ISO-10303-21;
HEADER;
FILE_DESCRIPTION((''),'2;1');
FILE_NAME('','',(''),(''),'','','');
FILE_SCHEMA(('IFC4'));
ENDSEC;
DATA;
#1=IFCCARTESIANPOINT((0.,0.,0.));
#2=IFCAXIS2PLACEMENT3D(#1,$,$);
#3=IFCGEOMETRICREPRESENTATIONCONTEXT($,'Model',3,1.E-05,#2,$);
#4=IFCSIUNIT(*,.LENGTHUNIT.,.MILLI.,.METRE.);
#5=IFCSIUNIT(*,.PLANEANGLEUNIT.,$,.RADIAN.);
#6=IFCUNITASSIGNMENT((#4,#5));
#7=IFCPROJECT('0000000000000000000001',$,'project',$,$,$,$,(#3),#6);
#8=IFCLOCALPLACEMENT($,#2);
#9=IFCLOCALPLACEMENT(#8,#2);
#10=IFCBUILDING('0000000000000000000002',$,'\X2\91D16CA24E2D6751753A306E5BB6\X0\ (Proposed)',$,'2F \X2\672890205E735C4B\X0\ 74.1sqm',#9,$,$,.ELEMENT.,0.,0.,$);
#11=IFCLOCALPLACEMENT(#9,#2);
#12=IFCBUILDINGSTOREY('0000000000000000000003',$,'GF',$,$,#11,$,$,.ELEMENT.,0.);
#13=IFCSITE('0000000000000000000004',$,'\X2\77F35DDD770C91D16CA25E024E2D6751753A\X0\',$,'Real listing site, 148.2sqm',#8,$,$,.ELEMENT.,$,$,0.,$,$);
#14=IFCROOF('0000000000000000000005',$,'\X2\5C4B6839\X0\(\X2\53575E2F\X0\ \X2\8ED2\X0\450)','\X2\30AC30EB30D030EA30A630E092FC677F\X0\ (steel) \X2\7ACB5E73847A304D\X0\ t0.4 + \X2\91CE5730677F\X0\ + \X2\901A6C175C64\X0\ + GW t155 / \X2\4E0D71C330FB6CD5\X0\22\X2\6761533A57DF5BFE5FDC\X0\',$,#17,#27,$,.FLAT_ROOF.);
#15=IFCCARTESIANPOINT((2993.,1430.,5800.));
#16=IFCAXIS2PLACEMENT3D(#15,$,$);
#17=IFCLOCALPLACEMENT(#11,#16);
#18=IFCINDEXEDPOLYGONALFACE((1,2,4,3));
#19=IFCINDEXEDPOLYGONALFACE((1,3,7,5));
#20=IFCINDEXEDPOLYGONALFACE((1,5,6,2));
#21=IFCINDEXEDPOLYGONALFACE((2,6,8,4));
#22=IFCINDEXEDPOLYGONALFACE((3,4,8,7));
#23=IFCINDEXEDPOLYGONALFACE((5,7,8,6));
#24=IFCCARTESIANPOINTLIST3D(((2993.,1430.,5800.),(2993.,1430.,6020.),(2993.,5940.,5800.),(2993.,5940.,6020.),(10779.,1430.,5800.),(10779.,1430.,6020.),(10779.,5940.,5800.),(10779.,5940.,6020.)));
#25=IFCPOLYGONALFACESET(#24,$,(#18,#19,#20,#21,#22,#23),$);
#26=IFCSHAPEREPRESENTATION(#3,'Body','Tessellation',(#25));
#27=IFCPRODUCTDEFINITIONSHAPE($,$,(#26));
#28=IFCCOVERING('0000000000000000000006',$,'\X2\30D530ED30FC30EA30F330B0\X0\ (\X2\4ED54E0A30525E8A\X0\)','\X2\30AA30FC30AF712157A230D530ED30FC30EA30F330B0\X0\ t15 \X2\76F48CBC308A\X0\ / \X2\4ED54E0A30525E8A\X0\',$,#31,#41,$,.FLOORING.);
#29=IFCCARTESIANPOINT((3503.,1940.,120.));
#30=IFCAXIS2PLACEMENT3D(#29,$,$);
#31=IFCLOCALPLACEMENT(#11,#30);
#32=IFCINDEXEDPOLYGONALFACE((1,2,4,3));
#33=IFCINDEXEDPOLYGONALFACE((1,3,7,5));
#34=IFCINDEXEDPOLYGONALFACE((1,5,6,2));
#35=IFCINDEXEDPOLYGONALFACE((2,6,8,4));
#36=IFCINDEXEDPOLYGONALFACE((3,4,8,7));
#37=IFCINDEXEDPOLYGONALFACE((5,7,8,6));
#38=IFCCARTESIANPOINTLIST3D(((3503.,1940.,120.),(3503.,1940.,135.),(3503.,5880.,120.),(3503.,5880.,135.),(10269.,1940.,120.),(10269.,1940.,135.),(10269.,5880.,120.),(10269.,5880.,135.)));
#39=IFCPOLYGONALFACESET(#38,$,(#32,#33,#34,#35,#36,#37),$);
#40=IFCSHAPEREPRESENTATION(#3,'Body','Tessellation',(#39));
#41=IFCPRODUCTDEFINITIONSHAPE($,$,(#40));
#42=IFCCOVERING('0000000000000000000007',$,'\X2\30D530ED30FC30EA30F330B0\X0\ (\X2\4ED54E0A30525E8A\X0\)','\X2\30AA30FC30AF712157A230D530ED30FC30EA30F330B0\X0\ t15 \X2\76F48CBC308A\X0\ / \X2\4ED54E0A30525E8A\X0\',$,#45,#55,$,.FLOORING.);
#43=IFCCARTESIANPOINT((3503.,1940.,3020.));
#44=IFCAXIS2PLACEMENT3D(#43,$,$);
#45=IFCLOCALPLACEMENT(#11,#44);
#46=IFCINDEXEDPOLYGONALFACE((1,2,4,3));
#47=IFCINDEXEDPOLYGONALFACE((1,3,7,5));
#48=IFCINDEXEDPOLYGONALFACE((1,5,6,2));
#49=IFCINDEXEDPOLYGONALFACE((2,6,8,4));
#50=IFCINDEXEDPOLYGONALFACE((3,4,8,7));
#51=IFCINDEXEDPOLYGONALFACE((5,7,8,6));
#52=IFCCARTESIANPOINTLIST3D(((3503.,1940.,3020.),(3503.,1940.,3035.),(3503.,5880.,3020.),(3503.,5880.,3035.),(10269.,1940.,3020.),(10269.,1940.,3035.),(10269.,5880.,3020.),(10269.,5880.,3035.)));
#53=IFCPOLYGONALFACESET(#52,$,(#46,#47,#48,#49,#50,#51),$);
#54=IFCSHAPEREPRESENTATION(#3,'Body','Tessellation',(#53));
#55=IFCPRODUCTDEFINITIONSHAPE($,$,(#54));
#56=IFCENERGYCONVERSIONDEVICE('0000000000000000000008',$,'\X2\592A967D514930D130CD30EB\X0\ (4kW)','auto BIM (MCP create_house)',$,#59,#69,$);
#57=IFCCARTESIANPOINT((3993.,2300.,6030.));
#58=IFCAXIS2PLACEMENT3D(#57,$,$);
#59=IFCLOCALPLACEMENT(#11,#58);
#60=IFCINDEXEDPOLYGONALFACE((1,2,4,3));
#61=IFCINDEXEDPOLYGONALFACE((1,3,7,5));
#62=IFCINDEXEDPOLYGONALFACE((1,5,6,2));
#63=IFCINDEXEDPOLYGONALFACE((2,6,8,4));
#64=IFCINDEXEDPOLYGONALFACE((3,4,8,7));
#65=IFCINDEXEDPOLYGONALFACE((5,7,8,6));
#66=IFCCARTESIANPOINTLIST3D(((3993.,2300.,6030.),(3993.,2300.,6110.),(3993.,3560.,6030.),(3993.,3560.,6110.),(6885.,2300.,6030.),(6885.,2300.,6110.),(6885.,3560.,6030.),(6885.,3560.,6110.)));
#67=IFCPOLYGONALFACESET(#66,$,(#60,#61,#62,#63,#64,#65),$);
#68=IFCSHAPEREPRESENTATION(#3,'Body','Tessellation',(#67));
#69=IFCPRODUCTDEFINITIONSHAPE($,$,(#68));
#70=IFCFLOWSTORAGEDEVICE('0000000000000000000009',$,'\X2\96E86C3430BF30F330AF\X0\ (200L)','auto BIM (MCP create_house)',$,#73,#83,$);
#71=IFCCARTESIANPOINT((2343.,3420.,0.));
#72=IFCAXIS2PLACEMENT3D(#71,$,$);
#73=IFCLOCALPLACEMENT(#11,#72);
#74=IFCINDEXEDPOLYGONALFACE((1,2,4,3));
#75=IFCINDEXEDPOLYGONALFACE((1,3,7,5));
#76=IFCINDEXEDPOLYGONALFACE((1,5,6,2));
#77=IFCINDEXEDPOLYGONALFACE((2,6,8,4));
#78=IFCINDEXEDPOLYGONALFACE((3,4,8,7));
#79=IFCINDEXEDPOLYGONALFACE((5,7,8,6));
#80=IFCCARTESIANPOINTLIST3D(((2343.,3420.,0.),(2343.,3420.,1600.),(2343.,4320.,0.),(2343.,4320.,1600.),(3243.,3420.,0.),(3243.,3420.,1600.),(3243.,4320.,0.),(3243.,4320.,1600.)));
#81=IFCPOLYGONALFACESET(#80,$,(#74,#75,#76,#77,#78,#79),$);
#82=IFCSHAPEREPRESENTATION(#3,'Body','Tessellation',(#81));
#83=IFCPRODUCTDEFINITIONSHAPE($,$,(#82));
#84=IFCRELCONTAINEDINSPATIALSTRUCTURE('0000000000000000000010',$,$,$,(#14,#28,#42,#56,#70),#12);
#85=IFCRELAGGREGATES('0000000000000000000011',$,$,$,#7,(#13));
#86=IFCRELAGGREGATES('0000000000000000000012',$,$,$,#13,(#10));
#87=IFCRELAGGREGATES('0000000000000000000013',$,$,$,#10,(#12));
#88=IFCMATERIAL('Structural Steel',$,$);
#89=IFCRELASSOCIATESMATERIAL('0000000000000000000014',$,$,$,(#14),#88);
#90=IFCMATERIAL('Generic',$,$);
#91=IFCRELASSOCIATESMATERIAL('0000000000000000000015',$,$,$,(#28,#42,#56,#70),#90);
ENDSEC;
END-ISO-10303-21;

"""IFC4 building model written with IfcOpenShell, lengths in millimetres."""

from ifc_helpers import new_model, si_unit, frame, frame_2d, origin, place, context, project, spatial, rectangle, extrude, material, element, save


model = new_model("IFC4")

# Units and contexts
model_context = context("Model", 3, precision=1e-05, world=origin())
ifc_project = project(units=[si_unit("LENGTHUNIT", "METRE", prefix="MILLI"), si_unit("PLANEANGLEUNIT", "RADIAN")], contexts=[model_context])

# Site, building, storey
site_placement = place(None, origin())
site = spatial("IfcSite", under=ifc_project, at=site_placement, Name="石川県金沢市中村町", ObjectType="Real listing site, 148.2sqm", CompositionType="ELEMENT", RefElevation=0.0)
building_placement = place(site_placement, origin())
building = spatial("IfcBuilding", under=site, at=building_placement, Name="金沢中村町の家 (Proposed)", ObjectType="2F 木造平屋 74.1sqm", CompositionType="ELEMENT", ElevationOfRefHeight=0.0, ElevationOfTerrain=0.0)
storey_placement = place(building_placement, origin())
storey = spatial("IfcBuildingStorey", under=building, at=storey_placement, Name="GF", CompositionType="ELEMENT", Elevation=0.0)

# Roof
ifc_material_1 = material(Name="Structural Steel")
for number, where, name in (
    (1, (2993.0, 1430.0, 5800.0), "屋根(南帯 軒450)"),
):
    element("IfcRoof", number, at=place(storey_placement, frame(where)), inside=storey, material=ifc_material_1, Name=name, Description="ガルバリウム鋼板 (steel) 立平葺き t0.4 + 野地板 + 通気層 + GW t155 / 不燃・法22条区域対応", PredefinedType="FLAT_ROOF", context=model_context, shape_type="SweptSolid", body=[
        extrude(rectangle(XDim=7786.0, YDim=4510.0, at=frame_2d((3893.0, 2255.0))), frame((2993.0, 1430.0, 5800.0)), (0.0, 0.0, 1.0), 220.0),
    ])

# Coverings
ifc_material_2 = material(Name="Generic")
covering_1_placement = place(storey_placement, frame((3503.0, 1940.0, 120.0)))
element("IfcCovering", 2, at=covering_1_placement, inside=storey, material=ifc_material_2, Name="フローリング (仕上げ床)", Description="オーク無垢フローリング t15 直貼り / 仕上げ床", PredefinedType="FLOORING", context=model_context, shape_type="SweptSolid", body=[
    extrude(rectangle(XDim=6766.0, YDim=3940.0, at=frame_2d((3383.0, 1970.0))), frame((3503.0, 1940.0, 120.0)), (0.0, 0.0, 1.0), 15.0),
])
covering_2_placement = place(storey_placement, frame((3503.0, 1940.0, 3020.0)))
element("IfcCovering", 3, at=covering_2_placement, inside=storey, material=ifc_material_2, Name="フローリング (仕上げ床)", Description="オーク無垢フローリング t15 直貼り / 仕上げ床", PredefinedType="FLOORING", context=model_context, shape_type="SweptSolid", body=[
    extrude(rectangle(XDim=6766.0, YDim=3940.0, at=frame_2d((3383.0, 1970.0))), frame((3503.0, 1940.0, 3020.0)), (0.0, 0.0, 1.0), 15.0),
])

# Energy conversion device
energy_conversion_device_placement = place(storey_placement, frame((3993.0, 2300.0, 6030.0)))
element("IfcEnergyConversionDevice", 4, at=energy_conversion_device_placement, inside=storey, material=ifc_material_2, Name="太陽光パネル (4kW)", Description="auto BIM (MCP create_house)", context=model_context, shape_type="SweptSolid", body=[
    extrude(rectangle(XDim=2892.0, YDim=1260.0, at=frame_2d((1446.0, 630.0))), frame((3993.0, 2300.0, 6030.0)), (0.0, 0.0, 1.0), 80.0),
])

# Flow storage device
flow_storage_device_placement = place(storey_placement, frame((2343.0, 3420.0, 0.0)))
element("IfcFlowStorageDevice", 5, at=flow_storage_device_placement, inside=storey, material=ifc_material_2, Name="雨水タンク (200L)", Description="auto BIM (MCP create_house)", context=model_context, shape_type="SweptSolid", body=[
    extrude(rectangle(XDim=900.0, YDim=900.0, at=frame_2d((450.0, 450.0))), frame((2343.0, 3420.0, 0.0)), (0.0, 0.0, 1.0), 1600.0),
])

save(model, "model.ifc")
